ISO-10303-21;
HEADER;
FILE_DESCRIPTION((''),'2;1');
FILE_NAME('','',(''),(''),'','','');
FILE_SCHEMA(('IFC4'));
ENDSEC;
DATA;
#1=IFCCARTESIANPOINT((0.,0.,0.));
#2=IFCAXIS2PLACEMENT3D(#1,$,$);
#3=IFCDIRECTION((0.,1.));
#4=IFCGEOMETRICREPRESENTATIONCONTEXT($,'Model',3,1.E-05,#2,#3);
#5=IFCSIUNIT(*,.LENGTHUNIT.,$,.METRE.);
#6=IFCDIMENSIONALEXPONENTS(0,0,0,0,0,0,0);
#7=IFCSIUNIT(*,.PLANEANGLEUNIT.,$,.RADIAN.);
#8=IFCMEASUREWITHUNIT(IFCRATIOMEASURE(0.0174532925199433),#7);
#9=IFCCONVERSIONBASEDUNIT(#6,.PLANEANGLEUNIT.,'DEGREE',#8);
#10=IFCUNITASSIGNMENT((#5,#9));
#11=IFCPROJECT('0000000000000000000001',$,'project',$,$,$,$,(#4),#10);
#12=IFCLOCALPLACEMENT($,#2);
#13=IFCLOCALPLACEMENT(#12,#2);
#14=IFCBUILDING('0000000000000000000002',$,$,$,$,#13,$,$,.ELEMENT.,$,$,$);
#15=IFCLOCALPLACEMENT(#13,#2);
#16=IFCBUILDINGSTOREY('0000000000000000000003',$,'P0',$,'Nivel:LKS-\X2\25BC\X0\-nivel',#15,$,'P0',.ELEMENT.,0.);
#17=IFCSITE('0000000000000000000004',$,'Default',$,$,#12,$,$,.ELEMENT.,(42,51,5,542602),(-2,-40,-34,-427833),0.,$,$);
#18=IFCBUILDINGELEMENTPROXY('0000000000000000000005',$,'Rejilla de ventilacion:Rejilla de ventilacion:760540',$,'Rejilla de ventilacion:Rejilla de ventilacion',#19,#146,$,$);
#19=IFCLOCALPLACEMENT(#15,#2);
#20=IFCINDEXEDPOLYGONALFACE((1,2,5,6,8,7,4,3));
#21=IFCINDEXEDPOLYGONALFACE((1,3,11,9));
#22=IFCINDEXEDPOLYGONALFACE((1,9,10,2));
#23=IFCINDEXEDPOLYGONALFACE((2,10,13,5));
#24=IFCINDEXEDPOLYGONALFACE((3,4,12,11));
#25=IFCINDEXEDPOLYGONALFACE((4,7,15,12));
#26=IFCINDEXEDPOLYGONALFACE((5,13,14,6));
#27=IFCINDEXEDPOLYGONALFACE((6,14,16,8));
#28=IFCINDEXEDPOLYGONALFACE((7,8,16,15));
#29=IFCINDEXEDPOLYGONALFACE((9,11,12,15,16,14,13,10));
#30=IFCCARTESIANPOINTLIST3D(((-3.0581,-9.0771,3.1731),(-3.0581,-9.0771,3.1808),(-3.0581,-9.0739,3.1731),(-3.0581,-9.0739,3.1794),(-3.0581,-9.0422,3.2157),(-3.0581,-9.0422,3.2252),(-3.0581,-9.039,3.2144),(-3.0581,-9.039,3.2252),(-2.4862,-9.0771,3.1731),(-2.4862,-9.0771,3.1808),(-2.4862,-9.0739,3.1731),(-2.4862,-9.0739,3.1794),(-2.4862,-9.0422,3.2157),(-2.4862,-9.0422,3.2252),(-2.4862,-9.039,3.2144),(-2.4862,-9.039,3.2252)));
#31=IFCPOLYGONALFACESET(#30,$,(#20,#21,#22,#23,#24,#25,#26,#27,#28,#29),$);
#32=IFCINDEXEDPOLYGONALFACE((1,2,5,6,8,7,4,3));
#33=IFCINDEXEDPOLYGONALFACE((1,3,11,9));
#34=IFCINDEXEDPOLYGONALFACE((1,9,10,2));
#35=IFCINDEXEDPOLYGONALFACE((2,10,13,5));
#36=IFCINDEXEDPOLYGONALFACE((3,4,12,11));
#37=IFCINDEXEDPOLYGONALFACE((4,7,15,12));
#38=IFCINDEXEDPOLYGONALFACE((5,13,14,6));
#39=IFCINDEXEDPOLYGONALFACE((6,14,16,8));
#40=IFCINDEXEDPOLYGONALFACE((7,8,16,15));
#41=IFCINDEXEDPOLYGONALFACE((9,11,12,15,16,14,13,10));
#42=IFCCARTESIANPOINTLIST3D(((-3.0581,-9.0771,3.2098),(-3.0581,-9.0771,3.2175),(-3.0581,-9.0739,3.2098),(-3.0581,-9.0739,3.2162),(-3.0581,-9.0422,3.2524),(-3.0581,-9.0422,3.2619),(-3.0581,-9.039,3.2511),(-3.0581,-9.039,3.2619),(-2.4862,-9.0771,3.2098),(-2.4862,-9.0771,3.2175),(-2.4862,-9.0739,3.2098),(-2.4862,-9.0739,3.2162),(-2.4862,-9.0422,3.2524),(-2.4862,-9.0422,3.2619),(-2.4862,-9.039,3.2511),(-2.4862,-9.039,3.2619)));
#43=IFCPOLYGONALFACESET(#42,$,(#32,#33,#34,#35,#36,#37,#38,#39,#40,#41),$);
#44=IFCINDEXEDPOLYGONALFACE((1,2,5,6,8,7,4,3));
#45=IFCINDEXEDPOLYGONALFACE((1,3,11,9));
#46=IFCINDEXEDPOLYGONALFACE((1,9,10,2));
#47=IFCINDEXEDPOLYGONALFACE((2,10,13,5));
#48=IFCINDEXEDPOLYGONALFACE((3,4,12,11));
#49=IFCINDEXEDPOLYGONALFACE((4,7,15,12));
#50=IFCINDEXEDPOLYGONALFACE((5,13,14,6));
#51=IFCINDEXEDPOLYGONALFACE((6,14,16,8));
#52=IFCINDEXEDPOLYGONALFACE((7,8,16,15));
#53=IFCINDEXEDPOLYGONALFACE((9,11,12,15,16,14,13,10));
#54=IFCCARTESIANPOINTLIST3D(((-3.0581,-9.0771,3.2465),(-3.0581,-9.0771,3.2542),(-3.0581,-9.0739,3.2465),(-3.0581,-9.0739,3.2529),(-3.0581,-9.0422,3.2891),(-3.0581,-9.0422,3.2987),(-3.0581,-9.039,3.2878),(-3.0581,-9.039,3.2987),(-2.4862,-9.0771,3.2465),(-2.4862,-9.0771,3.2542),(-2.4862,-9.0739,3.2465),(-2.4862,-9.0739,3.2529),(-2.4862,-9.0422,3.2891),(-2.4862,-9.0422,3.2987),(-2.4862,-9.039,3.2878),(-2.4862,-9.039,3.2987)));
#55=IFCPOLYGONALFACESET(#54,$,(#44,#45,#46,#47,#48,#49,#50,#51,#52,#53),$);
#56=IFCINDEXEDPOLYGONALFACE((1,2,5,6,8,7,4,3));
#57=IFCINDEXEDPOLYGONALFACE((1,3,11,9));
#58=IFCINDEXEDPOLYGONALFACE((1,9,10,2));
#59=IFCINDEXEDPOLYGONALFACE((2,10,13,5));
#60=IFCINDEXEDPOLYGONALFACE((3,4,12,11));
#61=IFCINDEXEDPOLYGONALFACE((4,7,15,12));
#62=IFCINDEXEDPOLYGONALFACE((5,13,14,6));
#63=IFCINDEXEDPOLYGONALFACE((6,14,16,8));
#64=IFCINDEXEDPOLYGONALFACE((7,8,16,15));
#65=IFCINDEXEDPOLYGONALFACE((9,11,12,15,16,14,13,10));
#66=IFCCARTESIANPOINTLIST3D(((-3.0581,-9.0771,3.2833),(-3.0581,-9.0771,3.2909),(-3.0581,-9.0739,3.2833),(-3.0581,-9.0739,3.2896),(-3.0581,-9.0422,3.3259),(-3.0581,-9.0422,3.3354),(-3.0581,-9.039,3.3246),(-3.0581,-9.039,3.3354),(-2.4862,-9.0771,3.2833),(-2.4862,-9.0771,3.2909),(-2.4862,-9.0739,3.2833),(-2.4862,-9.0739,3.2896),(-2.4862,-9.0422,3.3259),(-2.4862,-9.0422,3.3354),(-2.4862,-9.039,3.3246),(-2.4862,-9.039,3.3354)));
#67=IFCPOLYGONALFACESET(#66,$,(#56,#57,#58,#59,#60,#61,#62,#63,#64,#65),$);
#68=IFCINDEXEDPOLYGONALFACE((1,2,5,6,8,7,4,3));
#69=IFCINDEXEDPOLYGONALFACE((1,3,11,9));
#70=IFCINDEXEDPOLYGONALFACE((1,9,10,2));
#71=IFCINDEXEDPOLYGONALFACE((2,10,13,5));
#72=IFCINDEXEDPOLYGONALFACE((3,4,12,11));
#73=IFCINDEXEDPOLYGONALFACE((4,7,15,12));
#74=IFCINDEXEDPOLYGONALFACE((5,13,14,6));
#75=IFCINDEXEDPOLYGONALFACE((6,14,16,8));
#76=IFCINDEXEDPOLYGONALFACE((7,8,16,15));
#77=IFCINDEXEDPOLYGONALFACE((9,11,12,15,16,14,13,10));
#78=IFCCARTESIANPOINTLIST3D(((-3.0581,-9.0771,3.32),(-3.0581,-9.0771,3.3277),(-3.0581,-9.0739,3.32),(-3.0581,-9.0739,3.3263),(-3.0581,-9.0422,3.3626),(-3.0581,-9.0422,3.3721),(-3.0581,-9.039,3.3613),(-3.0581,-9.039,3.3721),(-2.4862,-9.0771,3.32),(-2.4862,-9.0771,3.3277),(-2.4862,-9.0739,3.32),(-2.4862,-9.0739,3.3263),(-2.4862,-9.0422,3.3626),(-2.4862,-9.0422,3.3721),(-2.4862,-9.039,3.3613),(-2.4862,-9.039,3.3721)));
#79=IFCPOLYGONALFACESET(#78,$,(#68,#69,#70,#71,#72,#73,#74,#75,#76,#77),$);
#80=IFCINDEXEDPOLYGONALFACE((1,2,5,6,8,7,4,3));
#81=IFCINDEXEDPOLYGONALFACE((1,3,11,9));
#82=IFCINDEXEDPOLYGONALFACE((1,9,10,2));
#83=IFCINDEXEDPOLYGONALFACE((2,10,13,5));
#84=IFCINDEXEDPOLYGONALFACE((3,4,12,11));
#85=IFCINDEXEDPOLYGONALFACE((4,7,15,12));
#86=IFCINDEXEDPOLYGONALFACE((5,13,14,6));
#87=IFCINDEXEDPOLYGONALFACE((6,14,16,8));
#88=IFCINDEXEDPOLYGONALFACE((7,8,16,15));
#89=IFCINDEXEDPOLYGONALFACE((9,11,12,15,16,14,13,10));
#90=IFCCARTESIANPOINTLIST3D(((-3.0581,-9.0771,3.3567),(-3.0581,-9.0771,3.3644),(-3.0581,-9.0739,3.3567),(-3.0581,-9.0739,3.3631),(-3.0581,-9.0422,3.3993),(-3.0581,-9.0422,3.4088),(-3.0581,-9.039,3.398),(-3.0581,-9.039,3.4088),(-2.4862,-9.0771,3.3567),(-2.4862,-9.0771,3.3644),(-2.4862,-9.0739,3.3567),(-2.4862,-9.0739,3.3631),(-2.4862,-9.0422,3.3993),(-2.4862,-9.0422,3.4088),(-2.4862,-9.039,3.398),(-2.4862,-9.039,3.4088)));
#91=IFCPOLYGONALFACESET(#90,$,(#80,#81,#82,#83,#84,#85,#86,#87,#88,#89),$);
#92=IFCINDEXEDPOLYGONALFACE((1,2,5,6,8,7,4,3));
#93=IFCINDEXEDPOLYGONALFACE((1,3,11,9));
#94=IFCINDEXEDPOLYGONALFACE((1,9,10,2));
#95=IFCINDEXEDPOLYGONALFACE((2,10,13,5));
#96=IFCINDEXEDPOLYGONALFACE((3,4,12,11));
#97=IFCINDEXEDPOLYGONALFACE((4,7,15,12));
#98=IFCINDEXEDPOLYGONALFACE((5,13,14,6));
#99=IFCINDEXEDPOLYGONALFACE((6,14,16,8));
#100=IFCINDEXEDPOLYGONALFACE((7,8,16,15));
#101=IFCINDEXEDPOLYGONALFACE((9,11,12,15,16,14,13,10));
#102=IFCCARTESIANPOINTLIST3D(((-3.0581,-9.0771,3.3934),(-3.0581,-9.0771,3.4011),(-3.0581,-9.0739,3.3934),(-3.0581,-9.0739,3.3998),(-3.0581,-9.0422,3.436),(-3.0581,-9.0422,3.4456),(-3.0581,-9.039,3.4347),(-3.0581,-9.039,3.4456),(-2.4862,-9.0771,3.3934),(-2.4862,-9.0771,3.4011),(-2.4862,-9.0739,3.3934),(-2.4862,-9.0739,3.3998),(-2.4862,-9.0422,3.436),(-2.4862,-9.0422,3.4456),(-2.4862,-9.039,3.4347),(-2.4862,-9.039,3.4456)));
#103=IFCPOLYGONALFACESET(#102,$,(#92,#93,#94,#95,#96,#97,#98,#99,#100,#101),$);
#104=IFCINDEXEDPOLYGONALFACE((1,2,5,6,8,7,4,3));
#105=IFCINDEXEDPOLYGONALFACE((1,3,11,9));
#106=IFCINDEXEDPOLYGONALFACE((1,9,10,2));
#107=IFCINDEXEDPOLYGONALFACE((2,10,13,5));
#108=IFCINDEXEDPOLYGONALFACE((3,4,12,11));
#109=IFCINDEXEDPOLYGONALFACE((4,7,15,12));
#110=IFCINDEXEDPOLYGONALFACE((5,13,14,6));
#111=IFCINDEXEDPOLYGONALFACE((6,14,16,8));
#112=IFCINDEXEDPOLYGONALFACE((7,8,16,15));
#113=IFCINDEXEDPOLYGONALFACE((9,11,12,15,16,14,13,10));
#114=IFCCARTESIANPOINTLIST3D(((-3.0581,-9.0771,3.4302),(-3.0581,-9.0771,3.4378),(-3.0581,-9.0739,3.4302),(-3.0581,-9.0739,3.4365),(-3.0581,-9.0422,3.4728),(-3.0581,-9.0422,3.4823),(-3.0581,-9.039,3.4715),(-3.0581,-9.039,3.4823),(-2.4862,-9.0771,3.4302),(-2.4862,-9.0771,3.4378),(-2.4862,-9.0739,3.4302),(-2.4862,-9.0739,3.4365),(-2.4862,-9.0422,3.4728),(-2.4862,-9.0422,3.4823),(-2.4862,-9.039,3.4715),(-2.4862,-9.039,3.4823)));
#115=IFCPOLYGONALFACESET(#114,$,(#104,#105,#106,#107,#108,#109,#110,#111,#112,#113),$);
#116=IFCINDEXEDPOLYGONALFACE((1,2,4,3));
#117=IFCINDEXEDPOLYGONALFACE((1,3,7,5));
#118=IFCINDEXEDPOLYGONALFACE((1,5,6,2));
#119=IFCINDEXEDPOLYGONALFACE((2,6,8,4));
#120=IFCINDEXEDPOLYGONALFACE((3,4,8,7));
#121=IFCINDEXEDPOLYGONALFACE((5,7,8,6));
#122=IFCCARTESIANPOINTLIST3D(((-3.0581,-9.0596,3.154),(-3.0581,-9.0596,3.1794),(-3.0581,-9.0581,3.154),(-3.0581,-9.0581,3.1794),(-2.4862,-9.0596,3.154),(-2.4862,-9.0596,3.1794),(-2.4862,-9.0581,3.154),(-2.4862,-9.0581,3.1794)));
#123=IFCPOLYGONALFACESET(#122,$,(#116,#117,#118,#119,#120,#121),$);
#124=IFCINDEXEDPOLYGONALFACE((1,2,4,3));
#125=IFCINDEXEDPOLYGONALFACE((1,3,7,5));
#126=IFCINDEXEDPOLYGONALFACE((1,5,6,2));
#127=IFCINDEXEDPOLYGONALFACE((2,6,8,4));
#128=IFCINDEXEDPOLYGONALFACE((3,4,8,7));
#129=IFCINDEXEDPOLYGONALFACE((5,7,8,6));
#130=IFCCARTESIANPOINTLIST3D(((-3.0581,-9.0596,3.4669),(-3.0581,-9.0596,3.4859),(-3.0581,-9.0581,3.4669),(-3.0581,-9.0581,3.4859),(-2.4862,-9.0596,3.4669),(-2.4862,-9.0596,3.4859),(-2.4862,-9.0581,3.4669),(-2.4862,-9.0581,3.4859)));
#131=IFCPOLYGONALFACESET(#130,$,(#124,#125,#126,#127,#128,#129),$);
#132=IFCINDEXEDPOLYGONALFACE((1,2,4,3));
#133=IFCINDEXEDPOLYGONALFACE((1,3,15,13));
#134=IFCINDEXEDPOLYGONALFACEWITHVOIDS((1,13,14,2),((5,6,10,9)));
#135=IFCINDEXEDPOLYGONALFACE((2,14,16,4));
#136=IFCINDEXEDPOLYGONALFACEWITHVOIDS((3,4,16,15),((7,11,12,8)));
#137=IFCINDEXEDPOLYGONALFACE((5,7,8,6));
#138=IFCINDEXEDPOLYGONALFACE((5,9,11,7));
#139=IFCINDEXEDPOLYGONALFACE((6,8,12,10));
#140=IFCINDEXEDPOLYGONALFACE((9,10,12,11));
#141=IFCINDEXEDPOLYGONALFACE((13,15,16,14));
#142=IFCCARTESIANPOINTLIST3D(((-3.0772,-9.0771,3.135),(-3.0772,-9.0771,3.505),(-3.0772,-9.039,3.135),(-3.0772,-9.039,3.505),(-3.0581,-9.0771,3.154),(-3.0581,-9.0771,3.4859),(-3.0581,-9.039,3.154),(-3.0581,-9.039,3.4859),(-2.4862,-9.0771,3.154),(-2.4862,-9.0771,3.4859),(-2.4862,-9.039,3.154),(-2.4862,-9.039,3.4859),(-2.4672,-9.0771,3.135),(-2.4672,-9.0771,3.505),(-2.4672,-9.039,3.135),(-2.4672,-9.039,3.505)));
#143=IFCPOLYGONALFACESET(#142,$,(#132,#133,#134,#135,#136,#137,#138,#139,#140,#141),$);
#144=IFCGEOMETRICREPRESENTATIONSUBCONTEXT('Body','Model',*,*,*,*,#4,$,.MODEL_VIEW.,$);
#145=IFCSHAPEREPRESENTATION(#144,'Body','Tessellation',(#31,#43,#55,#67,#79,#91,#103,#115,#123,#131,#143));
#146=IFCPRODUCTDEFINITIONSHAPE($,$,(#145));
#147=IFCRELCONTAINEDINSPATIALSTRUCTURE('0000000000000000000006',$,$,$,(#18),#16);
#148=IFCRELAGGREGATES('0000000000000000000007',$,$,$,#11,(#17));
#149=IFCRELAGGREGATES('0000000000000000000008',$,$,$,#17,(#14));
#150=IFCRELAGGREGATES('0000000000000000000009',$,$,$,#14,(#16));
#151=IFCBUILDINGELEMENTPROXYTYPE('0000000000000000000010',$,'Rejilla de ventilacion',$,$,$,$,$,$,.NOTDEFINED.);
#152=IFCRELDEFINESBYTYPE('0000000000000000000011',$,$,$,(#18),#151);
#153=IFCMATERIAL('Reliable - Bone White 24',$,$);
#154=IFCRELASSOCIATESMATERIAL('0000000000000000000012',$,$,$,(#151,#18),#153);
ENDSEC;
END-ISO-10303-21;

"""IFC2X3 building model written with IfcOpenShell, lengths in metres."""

from ifc_helpers import new_model, entity, si_unit, converted_unit, direction, frame, frame_2d, origin, place, context, subcontext, project, spatial, polyline, rectangle, outline, extrude, source, transform, mapped, material, type_object, type_shapes, element, save


model = new_model("IFC2X3")

# Units and contexts
model_context = context("Model", 3, precision=1e-05, world=origin(), true_north=direction((0.0, 1.0)))
body_context = subcontext(model_context, "Body", "Model", "MODEL_VIEW")
ifc_project = project(units=[si_unit("LENGTHUNIT", "METRE"), converted_unit("PLANEANGLEUNIT", "DEGREE", entity("IfcRatioMeasure", 0.0174532925199433), si_unit("PLANEANGLEUNIT", "RADIAN"), dimensions=[0, 0, 0, 0, 0, 0, 0])], contexts=[model_context])

# Site, building, storey
site_placement = place(None, origin())
site = spatial("IfcSite", under=ifc_project, at=site_placement, Name="Default", CompositionType="ELEMENT", RefLatitude=(42, 51, 5, 542602), RefLongitude=(-2, -40, -34, -427833), RefElevation=0.0)
building_placement = place(site_placement, origin())
building = spatial("IfcBuilding", under=site, at=building_placement, CompositionType="ELEMENT")
storey_placement = place(building_placement, origin())
storey = spatial("IfcBuildingStorey", under=building, at=storey_placement, Name="P0", ObjectType="Nivel:LKS-▼-nivel", LongName="P0", CompositionType="ELEMENT", Elevation=0.0)

# Building element proxy
ifc_material_1 = material(Name="Reliable - Bone White 24")
building_element_proxy_type_1 = type_object("IfcBuildingElementProxyType", Name="Rejilla de ventilacion", PredefinedType="NOTDEFINED", material=ifc_material_1)
shared_shape_1 = source(origin(), body_context, "Body", "SweptSolid", [
    extrude(outline(polyline([(0.0173, 0.0159), (0.0269, 0.0159), (0.0269, 0.0191), (0.016, 0.0191), (-0.0189, -0.0159), (-0.0253, -0.0159), (-0.0253, -0.019), (-0.0176, -0.019), (0.0173, 0.0159)])), frame((-0.2859, 0.126, 1.2174), z_axis=(1.0, 0.0, 0.0), x_axis=(0.0, 0.0, 1.0)), (0.0, 0.0, 1.0), 0.5719),
    extrude(outline(polyline([(0.0173, 0.0159), (0.0269, 0.0159), (0.0269, 0.0191), (0.016, 0.0191), (-0.0189, -0.0159), (-0.0253, -0.0159), (-0.0253, -0.019), (-0.0176, -0.019), (0.0173, 0.0159)])), frame((-0.2859, 0.126, 1.2541), z_axis=(1.0, 0.0, 0.0), x_axis=(0.0, 0.0, 1.0)), (0.0, 0.0, 1.0), 0.5719),
    extrude(outline(polyline([(0.0173, 0.0159), (0.0269, 0.0159), (0.0269, 0.0191), (0.016, 0.0191), (-0.0189, -0.0159), (-0.0253, -0.0159), (-0.0253, -0.019), (-0.0176, -0.019), (0.0173, 0.0159)])), frame((-0.2859, 0.126, 1.2908), z_axis=(1.0, 0.0, 0.0), x_axis=(0.0, 0.0, 1.0)), (0.0, 0.0, 1.0), 0.5719),
    extrude(outline(polyline([(0.0173, 0.0159), (0.0269, 0.0159), (0.0269, 0.0191), (0.016, 0.0191), (-0.0189, -0.0159), (-0.0253, -0.0159), (-0.0253, -0.019), (-0.0176, -0.019), (0.0173, 0.0159)])), frame((-0.2859, 0.126, 1.3275), z_axis=(1.0, 0.0, 0.0), x_axis=(0.0, 0.0, 1.0)), (0.0, 0.0, 1.0), 0.5719),
    extrude(outline(polyline([(0.0173, 0.0159), (0.0269, 0.0159), (0.0269, 0.0191), (0.016, 0.0191), (-0.0189, -0.0159), (-0.0253, -0.0159), (-0.0253, -0.019), (-0.0176, -0.019), (0.0173, 0.0159)])), frame((-0.2859, 0.126, 1.3643), z_axis=(1.0, 0.0, 0.0), x_axis=(0.0, 0.0, 1.0)), (0.0, 0.0, 1.0), 0.5719),
    extrude(outline(polyline([(0.0173, 0.0159), (0.0269, 0.0159), (0.0269, 0.0191), (0.016, 0.0191), (-0.0189, -0.0159), (-0.0253, -0.0159), (-0.0253, -0.019), (-0.0176, -0.019), (0.0173, 0.0159)])), frame((-0.2859, 0.126, 1.401), z_axis=(1.0, 0.0, 0.0), x_axis=(0.0, 0.0, 1.0)), (0.0, 0.0, 1.0), 0.5719),
    extrude(outline(polyline([(0.0173, 0.0159), (0.0269, 0.0159), (0.0269, 0.0191), (0.016, 0.0191), (-0.0189, -0.0159), (-0.0253, -0.0159), (-0.0253, -0.019), (-0.0176, -0.019), (0.0173, 0.0159)])), frame((-0.2859, 0.126, 1.4377), z_axis=(1.0, 0.0, 0.0), x_axis=(0.0, 0.0, 1.0)), (0.0, 0.0, 1.0), 0.5719),
    extrude(outline(polyline([(0.0173, 0.0159), (0.0269, 0.0159), (0.0269, 0.0191), (0.016, 0.0191), (-0.0189, -0.0159), (-0.0253, -0.0159), (-0.0253, -0.019), (-0.0176, -0.019), (0.0173, 0.0159)])), frame((-0.2859, 0.126, 1.4744), z_axis=(1.0, 0.0, 0.0), x_axis=(0.0, 0.0, 1.0)), (0.0, 0.0, 1.0), 0.5719),
    extrude(rectangle(XDim=0.5719, YDim=0.0016, at=frame_2d((0.0, 0.0), x_axis=(1.0, 0.0))), frame((0.0, 0.1267, 1.173), z_axis=(0.0, 0.0, 1.0), x_axis=(-1.0, 0.0, 0.0)), (0.0, 0.0, 1.0), 0.0254),
    extrude(rectangle(XDim=0.5719, YDim=0.0016, at=frame_2d((0.0, 0.0), x_axis=(1.0, 0.0))), frame((0.0, 0.1267, 1.4859), z_axis=(0.0, 0.0, 1.0), x_axis=(-1.0, 0.0, 0.0)), (0.0, 0.0, 1.0), 0.0191),
    extrude(outline(polyline([(-0.185, -0.305), (0.185, -0.305), (0.185, 0.305), (-0.185, 0.305), (-0.185, -0.305)]), holes=[polyline([(-0.166, -0.286), (-0.166, 0.286), (0.166, 0.286), (0.166, -0.286), (-0.166, -0.286)])]), frame((0.0, 0.1069, 1.339), z_axis=(0.0, 1.0, 0.0), x_axis=(0.0, 0.0, 1.0)), (0.0, 0.0, 1.0), 0.0381),
])
type_shapes(building_element_proxy_type_1, [shared_shape_1])
for number, where, z_axis, x_axis, name in (
    (1, (-2.7722, -8.9321, 1.981), (0.0, 0.0, 1.0), (-1.0, 0.0, 0.0), "Rejilla de ventilacion:Rejilla de ventilacion:760540"),
):
    element("IfcBuildingElementProxy", number, at=place(storey_placement, frame(where, z_axis=z_axis, x_axis=x_axis)), inside=storey, type_object=building_element_proxy_type_1, material=ifc_material_1, Name=name, ObjectType="Rejilla de ventilacion:Rejilla de ventilacion", context=body_context, shape_type="MappedRepresentation", body=[
        mapped(shared_shape_1, transform((0.0, 0.0, 0.0), scale=1.0)),
    ])

save(model, "model.ifc")
